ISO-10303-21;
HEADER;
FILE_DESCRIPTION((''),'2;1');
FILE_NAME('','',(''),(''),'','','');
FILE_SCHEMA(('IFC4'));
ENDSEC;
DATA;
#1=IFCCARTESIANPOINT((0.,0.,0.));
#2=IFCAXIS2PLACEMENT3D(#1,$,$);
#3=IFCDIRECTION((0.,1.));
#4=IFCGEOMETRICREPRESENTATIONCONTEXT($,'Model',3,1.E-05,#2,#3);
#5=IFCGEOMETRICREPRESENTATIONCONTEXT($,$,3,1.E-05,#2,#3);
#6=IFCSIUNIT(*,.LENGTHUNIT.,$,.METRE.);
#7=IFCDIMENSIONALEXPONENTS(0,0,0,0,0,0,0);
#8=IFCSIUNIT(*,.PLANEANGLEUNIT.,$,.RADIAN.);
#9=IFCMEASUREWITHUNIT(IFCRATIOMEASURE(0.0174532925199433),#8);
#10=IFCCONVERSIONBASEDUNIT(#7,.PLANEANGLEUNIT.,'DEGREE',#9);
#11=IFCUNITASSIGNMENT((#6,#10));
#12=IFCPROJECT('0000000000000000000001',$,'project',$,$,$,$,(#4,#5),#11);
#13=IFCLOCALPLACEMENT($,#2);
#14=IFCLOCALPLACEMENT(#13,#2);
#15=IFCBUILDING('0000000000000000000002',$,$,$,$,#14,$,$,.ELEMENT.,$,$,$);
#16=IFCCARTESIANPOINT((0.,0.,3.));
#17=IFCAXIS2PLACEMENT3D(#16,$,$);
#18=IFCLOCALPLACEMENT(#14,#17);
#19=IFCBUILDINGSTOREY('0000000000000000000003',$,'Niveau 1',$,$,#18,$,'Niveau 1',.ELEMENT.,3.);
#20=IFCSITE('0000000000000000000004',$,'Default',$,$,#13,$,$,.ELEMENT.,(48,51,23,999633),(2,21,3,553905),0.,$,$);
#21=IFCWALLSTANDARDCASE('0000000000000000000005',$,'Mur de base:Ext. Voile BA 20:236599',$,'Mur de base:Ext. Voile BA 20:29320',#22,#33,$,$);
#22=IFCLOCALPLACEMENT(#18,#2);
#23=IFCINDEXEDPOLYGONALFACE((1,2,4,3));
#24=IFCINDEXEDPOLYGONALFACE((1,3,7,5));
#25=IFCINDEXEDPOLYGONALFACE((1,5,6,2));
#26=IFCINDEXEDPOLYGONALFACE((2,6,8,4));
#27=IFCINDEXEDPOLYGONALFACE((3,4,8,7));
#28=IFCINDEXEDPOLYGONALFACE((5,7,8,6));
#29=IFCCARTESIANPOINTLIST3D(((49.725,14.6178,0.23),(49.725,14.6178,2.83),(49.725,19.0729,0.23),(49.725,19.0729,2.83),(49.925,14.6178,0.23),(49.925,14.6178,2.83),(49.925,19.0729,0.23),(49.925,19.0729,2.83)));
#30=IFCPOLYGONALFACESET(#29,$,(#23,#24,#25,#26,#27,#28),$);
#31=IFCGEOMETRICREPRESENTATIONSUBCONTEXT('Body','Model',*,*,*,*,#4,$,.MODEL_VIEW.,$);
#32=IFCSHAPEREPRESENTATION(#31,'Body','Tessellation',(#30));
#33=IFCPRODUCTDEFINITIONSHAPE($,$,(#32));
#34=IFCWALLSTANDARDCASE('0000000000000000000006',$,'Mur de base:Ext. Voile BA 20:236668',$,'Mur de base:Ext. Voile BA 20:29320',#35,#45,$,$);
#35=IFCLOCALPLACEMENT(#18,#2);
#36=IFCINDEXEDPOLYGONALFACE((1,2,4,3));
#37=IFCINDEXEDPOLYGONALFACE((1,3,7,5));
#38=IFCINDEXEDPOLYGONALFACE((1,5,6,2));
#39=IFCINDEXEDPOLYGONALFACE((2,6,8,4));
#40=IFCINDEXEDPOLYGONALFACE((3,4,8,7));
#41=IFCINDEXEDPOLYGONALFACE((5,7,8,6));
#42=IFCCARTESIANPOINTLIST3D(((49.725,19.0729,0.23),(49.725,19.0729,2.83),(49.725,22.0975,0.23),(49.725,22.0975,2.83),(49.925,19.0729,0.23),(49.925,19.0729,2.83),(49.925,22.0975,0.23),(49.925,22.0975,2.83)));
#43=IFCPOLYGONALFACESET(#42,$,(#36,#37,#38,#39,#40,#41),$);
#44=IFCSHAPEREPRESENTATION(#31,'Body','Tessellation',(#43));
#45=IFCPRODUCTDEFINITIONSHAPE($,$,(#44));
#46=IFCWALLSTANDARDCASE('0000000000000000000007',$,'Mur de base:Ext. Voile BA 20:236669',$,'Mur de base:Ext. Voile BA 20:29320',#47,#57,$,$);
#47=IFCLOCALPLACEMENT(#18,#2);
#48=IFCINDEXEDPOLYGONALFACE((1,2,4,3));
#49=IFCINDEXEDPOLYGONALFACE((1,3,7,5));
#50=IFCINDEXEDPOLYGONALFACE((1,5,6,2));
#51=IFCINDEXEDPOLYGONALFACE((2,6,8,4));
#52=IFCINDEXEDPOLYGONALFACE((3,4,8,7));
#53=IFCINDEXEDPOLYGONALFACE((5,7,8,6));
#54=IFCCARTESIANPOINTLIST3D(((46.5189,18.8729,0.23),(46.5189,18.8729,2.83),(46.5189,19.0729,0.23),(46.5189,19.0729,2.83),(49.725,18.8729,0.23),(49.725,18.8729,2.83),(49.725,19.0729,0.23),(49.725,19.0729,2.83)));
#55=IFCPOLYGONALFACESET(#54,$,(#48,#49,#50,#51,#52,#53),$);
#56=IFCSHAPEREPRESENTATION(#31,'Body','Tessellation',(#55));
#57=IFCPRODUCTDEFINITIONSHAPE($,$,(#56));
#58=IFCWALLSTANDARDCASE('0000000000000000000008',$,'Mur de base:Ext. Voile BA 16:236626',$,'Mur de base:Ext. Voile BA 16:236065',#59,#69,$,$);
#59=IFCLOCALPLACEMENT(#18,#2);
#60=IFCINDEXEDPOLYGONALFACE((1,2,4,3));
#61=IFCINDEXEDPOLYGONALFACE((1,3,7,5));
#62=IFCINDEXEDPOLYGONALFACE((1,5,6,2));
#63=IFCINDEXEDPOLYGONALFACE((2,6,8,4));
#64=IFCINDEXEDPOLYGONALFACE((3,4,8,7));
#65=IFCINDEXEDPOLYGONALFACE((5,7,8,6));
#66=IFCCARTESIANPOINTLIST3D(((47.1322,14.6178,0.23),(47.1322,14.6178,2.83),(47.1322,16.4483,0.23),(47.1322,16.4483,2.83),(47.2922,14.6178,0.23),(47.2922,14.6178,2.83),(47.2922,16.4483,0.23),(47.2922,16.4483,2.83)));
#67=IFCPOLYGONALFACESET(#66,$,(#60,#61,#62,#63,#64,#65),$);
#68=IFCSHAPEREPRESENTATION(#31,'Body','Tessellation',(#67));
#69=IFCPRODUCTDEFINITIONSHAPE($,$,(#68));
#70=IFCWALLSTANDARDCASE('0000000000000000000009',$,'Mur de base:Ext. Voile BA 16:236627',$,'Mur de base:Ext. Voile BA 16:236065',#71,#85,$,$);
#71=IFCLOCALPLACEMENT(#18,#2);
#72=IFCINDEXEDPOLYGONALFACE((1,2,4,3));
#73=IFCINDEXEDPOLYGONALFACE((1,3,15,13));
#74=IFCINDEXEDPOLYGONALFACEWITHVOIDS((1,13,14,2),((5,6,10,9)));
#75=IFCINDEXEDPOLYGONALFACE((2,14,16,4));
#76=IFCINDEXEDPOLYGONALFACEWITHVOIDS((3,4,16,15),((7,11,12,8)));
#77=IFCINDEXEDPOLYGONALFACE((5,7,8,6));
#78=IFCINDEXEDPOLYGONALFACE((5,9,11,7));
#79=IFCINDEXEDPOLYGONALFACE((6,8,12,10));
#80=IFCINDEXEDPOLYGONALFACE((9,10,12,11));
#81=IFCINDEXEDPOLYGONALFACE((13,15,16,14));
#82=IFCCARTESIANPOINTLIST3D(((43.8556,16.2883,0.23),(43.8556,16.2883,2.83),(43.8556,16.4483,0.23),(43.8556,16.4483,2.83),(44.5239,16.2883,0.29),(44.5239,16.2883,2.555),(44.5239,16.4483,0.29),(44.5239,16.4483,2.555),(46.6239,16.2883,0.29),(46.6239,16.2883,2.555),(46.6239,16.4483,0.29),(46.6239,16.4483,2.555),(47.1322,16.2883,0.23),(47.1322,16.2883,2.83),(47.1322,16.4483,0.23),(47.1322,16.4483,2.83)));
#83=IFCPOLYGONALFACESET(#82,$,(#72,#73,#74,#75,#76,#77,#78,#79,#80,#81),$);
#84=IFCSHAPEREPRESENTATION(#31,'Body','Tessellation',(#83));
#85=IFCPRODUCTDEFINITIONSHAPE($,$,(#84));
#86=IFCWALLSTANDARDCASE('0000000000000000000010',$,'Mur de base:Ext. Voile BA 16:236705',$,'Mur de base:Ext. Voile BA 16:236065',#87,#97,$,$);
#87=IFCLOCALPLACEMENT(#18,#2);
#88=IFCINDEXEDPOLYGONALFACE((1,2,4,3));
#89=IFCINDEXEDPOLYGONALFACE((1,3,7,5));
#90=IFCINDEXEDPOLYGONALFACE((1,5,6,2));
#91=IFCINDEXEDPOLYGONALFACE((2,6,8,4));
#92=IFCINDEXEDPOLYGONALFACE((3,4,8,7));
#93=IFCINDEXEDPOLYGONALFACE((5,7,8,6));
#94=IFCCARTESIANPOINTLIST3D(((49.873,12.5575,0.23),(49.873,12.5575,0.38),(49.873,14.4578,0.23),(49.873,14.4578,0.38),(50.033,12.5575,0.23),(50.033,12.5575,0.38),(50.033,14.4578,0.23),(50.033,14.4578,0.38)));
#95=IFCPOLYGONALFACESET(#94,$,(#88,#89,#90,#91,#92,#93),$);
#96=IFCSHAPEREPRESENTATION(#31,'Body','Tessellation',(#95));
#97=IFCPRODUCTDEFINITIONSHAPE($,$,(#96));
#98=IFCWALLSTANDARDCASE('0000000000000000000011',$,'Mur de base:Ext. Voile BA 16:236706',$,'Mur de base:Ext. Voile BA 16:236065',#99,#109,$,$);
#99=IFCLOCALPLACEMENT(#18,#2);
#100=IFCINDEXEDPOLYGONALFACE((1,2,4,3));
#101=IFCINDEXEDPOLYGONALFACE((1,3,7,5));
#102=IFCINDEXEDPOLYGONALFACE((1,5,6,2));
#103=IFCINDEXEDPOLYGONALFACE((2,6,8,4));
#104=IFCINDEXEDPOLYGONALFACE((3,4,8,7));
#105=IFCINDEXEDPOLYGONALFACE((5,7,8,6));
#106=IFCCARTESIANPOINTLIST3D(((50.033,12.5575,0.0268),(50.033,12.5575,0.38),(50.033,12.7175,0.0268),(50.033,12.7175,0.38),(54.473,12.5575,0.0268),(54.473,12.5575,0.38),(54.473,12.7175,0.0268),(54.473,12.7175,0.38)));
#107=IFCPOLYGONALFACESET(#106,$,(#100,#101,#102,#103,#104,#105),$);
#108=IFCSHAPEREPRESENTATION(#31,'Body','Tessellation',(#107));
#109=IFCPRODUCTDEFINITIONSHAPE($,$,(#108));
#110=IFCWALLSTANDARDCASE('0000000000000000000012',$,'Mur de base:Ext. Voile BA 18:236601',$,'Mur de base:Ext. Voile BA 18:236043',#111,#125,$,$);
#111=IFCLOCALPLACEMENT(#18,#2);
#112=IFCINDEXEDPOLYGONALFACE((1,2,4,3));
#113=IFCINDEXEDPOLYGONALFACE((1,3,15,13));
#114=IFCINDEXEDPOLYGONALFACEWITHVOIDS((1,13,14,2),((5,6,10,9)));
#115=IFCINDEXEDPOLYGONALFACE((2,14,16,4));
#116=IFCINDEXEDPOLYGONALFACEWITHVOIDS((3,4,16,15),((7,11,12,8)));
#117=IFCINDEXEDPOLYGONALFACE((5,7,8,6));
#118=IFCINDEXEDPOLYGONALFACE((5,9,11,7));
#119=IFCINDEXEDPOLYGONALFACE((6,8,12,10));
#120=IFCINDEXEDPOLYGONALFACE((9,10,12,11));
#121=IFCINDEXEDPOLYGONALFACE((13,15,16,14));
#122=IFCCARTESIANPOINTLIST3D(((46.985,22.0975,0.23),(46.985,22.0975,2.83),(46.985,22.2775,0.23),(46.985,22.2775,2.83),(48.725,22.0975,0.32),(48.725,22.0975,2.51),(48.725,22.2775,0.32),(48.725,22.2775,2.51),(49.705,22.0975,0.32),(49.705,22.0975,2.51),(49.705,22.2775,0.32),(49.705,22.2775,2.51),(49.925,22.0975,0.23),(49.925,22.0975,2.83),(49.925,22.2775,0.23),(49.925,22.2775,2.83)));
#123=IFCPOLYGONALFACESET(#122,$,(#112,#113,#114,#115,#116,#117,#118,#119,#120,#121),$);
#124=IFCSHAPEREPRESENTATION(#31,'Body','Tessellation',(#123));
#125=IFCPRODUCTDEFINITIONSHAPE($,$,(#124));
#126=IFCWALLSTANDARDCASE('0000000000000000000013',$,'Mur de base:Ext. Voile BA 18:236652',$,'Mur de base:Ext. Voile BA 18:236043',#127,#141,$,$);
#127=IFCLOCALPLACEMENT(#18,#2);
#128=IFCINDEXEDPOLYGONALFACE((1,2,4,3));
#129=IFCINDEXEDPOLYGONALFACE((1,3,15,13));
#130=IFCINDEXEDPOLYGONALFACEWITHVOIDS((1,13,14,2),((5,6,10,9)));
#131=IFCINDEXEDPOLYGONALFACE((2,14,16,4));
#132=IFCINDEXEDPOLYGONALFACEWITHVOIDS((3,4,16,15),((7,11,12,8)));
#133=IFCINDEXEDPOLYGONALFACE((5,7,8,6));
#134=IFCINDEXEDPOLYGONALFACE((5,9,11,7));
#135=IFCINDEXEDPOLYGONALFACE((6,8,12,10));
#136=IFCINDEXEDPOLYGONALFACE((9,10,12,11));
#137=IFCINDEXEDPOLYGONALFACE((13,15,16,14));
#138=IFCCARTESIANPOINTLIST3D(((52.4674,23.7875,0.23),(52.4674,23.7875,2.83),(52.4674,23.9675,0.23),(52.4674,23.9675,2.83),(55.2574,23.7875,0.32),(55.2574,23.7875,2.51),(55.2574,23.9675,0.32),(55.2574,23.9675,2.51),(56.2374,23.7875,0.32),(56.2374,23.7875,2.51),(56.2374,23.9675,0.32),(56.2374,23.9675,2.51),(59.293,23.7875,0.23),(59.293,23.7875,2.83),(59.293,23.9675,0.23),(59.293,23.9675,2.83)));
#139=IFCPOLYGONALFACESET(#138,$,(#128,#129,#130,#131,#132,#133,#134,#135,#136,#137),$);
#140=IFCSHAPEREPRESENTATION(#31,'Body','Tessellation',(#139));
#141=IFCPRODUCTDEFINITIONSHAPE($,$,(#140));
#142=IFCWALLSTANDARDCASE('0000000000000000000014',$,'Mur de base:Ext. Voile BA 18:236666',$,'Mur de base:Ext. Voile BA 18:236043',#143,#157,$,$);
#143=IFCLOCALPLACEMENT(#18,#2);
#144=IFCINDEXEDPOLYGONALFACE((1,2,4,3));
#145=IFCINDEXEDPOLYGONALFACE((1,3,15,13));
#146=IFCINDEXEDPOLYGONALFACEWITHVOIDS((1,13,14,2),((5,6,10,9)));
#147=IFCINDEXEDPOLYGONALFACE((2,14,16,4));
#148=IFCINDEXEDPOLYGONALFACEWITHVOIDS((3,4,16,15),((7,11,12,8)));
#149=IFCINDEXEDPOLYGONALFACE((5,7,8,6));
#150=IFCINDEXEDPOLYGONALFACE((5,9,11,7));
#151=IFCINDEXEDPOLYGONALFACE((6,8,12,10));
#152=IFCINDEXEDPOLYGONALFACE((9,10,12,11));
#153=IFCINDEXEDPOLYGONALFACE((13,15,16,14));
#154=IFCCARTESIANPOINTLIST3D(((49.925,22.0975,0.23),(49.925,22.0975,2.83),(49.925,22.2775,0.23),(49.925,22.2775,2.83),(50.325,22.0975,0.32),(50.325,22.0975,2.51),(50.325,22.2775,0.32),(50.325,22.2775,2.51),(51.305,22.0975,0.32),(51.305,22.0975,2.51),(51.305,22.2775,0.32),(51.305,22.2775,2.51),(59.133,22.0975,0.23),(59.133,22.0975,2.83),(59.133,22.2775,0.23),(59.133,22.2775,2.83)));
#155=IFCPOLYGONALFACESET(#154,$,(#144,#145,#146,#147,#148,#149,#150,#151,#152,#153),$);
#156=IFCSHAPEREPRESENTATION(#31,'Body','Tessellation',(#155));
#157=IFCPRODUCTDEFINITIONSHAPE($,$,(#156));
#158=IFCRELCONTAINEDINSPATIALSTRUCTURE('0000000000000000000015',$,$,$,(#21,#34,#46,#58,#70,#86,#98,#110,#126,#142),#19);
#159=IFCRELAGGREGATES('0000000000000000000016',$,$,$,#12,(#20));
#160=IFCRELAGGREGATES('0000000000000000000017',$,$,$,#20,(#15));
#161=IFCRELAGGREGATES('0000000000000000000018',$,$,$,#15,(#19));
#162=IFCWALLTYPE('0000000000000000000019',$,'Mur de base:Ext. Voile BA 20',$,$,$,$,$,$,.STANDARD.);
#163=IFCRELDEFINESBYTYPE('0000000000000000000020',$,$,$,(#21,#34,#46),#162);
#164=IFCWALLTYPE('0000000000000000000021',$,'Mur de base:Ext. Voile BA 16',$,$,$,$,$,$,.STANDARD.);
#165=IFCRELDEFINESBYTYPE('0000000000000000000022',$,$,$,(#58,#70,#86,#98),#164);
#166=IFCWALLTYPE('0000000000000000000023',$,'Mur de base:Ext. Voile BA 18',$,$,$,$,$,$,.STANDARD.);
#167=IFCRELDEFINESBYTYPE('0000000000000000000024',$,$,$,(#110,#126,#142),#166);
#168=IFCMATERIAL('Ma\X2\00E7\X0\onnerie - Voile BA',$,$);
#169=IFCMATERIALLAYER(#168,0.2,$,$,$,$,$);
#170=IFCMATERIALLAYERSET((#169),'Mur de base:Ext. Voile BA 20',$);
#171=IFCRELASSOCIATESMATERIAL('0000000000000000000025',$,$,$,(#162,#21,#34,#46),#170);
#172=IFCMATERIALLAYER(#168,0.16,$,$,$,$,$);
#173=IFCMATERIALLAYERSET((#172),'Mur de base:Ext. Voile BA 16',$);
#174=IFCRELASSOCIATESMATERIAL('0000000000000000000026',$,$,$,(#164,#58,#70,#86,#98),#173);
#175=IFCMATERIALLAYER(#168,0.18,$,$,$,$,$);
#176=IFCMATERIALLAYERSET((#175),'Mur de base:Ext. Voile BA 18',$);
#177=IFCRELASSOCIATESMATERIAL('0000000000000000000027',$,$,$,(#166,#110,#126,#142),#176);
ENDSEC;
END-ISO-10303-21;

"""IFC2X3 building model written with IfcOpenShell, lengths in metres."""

from ifc_helpers import new_model, entity, si_unit, converted_unit, direction, frame, frame_2d, origin, place, context, subcontext, project, spatial, rectangle, extrude, material, layer, layer_set, layer_usage, type_object, element, save


model = new_model("IFC2X3")

# Units and contexts
model_context = context("Model", 3, precision=1e-05, world=origin(), true_north=direction((0.0, 1.0)))
context_of_model = context(None, 3, precision=1e-05, world=origin(), true_north=direction((0.0, 1.0)))
body_context = subcontext(model_context, "Body", "Model", "MODEL_VIEW")
ifc_project = project(units=[si_unit("LENGTHUNIT", "METRE"), converted_unit("PLANEANGLEUNIT", "DEGREE", entity("IfcRatioMeasure", 0.0174532925199433), si_unit("PLANEANGLEUNIT", "RADIAN"), dimensions=[0, 0, 0, 0, 0, 0, 0])], contexts=[model_context, context_of_model])

# Site, building, storey
site_placement = place(None, origin())
site = spatial("IfcSite", under=ifc_project, at=site_placement, Name="Default", CompositionType="ELEMENT", RefLatitude=(48, 51, 23, 999633), RefLongitude=(2, 21, 3, 553905), RefElevation=0.0)
building_placement = place(site_placement, origin())
building = spatial("IfcBuilding", under=site, at=building_placement, CompositionType="ELEMENT")
storey_placement = place(building_placement, frame((0.0, 0.0, 3.0)))
storey = spatial("IfcBuildingStorey", under=building, at=storey_placement, Name="Niveau 1", LongName="Niveau 1", CompositionType="ELEMENT", Elevation=3.0)

# Walls
ifc_material = material(Name="Maçonnerie - Voile BA")
ifc_layer_1 = layer(ifc_material, 0.2)
ifc_layer_set_1 = layer_set([ifc_layer_1], Name="Mur de base:Ext. Voile BA 20")
ifc_layer_usage_1 = layer_usage(ifc_layer_set_1, "AXIS2", "NEGATIVE", 0.1)
wall_type_1 = type_object("IfcWallType", Name="Mur de base:Ext. Voile BA 20", PredefinedType="STANDARD", material=ifc_layer_set_1)
wall_1_placement = place(storey_placement, frame((49.825, 19.0729, 0.23), z_axis=(0.0, 0.0, 1.0), x_axis=(0.0, -1.0, 0.0)))
element("IfcWallStandardCase", 1, at=wall_1_placement, inside=storey, type_object=wall_type_1, material=ifc_layer_usage_1, Name="Mur de base:Ext. Voile BA 20:236599", ObjectType="Mur de base:Ext. Voile BA 20:29320", context=body_context, shape_type="SweptSolid", body=[
    extrude(rectangle(XDim=4.4551, YDim=0.2, at=frame_2d((2.2275, 0.0), x_axis=(-1.0, 0.0))), origin(), (0.0, 0.0, 1.0), 2.6),
])
ifc_layer_usage_2 = layer_usage(ifc_layer_set_1, "AXIS2", "NEGATIVE", 0.1)
wall_2_placement = place(storey_placement, frame((49.825, 19.0729, 0.23), z_axis=(0.0, 0.0, 1.0), x_axis=(0.0, 1.0, 0.0)))
element("IfcWallStandardCase", 2, at=wall_2_placement, inside=storey, type_object=wall_type_1, material=ifc_layer_usage_2, Name="Mur de base:Ext. Voile BA 20:236668", ObjectType="Mur de base:Ext. Voile BA 20:29320", context=body_context, shape_type="SweptSolid", body=[
    extrude(rectangle(XDim=3.0246, YDim=0.2, at=frame_2d((1.5123, 0.0), x_axis=(-1.0, 0.0))), origin(), (0.0, 0.0, 1.0), 2.6),
])
ifc_layer_usage_3 = layer_usage(ifc_layer_set_1, "AXIS2", "POSITIVE", -0.1)
wall_3_placement = place(storey_placement, frame((49.725, 18.9729, 0.23), z_axis=(0.0, 0.0, 1.0), x_axis=(-1.0, 0.0, 0.0)))
element("IfcWallStandardCase", 3, at=wall_3_placement, inside=storey, type_object=wall_type_1, material=ifc_layer_usage_3, Name="Mur de base:Ext. Voile BA 20:236669", ObjectType="Mur de base:Ext. Voile BA 20:29320", context=body_context, shape_type="SweptSolid", body=[
    extrude(rectangle(XDim=3.2061, YDim=0.2, at=frame_2d((1.6031, 0.0), x_axis=(-1.0, 0.0))), origin(), (0.0, 0.0, 1.0), 2.6),
])
ifc_layer_2 = layer(ifc_material, 0.16)
ifc_layer_set_2 = layer_set([ifc_layer_2], Name="Mur de base:Ext. Voile BA 16")
ifc_layer_usage_4 = layer_usage(ifc_layer_set_2, "AXIS2", "NEGATIVE", 0.08)
wall_type_2 = type_object("IfcWallType", Name="Mur de base:Ext. Voile BA 16", PredefinedType="STANDARD", material=ifc_layer_set_2)
wall_4_placement = place(storey_placement, frame((47.2122, 14.6178, 0.23), z_axis=(0.0, 0.0, 1.0), x_axis=(0.0, 1.0, 0.0)))
element("IfcWallStandardCase", 4, at=wall_4_placement, inside=storey, type_object=wall_type_2, material=ifc_layer_usage_4, Name="Mur de base:Ext. Voile BA 16:236626", ObjectType="Mur de base:Ext. Voile BA 16:236065", context=body_context, shape_type="SweptSolid", body=[
    extrude(rectangle(XDim=1.8304, YDim=0.16, at=frame_2d((0.9152, 0.0), x_axis=(-1.0, 0.0))), origin(), (0.0, 0.0, 1.0), 2.6),
])

# Wall, opening
ifc_layer_usage_5 = layer_usage(ifc_layer_set_2, "AXIS2", "NEGATIVE", 0.08)
wall_5_placement = place(storey_placement, frame((47.1322, 16.3683, 0.23), z_axis=(0.0, 0.0, 1.0), x_axis=(-1.0, 0.0, 0.0)))
wall_5 = element("IfcWallStandardCase", 5, at=wall_5_placement, inside=storey, type_object=wall_type_2, material=ifc_layer_usage_5, Name="Mur de base:Ext. Voile BA 16:236627", ObjectType="Mur de base:Ext. Voile BA 16:236065", context=body_context, shape_type="SweptSolid", body=[
    extrude(rectangle(XDim=3.2767, YDim=0.16, at=frame_2d((1.6383, 0.0), x_axis=(-1.0, 0.0))), origin(), (0.0, 0.0, 1.0), 2.6),
])
opening_1_placement = place(wall_5_placement, origin())
element("IfcOpeningElement", 6, at=opening_1_placement, cuts=wall_5, ObjectType="Opening", context=body_context, shape_type="SweptSolid", body=[
    extrude(rectangle(XDim=2.265, YDim=2.1, at=frame_2d((0.0, 0.0), x_axis=(1.0, 0.0))), frame((1.5583, -0.08, 1.1925), z_axis=(0.0, 1.0, 0.0), x_axis=(0.0, 0.0, -1.0)), (0.0, 0.0, 1.0), 0.16),
])

# Walls
ifc_layer_usage_6 = layer_usage(ifc_layer_set_2, "AXIS2", "POSITIVE", -0.08)
wall_6_placement = place(storey_placement, frame((49.953, 14.4578, 0.23), z_axis=(0.0, 0.0, 1.0), x_axis=(0.0, -1.0, 0.0)))
element("IfcWallStandardCase", 7, at=wall_6_placement, inside=storey, type_object=wall_type_2, material=ifc_layer_usage_6, Name="Mur de base:Ext. Voile BA 16:236705", ObjectType="Mur de base:Ext. Voile BA 16:236065", context=body_context, shape_type="SweptSolid", body=[
    extrude(rectangle(XDim=1.9003, YDim=0.16, at=frame_2d((0.9502, 0.0), x_axis=(-1.0, 0.0))), origin(), (0.0, 0.0, 1.0), 0.15),
])
ifc_layer_usage_7 = layer_usage(ifc_layer_set_2, "AXIS2", "POSITIVE", -0.08)
wall_7_placement = place(storey_placement, frame((50.033, 12.6375, 0.0268)))
element("IfcWallStandardCase", 8, at=wall_7_placement, inside=storey, type_object=wall_type_2, material=ifc_layer_usage_7, Name="Mur de base:Ext. Voile BA 16:236706", ObjectType="Mur de base:Ext. Voile BA 16:236065", context=body_context, shape_type="SweptSolid", body=[
    extrude(rectangle(XDim=4.44, YDim=0.16, at=frame_2d((2.22, 0.0), x_axis=(-1.0, 0.0))), origin(), (0.0, 0.0, 1.0), 0.3532),
])

# Walls, openings
ifc_layer_3 = layer(ifc_material, 0.18)
ifc_layer_set_3 = layer_set([ifc_layer_3], Name="Mur de base:Ext. Voile BA 18")
ifc_layer_usage_8 = layer_usage(ifc_layer_set_3, "AXIS2", "NEGATIVE", 0.09)
wall_type_3 = type_object("IfcWallType", Name="Mur de base:Ext. Voile BA 18", PredefinedType="STANDARD", material=ifc_layer_set_3)
wall_8_placement = place(storey_placement, frame((46.985, 22.1875, 0.23)))
wall_8 = element("IfcWallStandardCase", 9, at=wall_8_placement, inside=storey, type_object=wall_type_3, material=ifc_layer_usage_8, Name="Mur de base:Ext. Voile BA 18:236601", ObjectType="Mur de base:Ext. Voile BA 18:236043", context=body_context, shape_type="SweptSolid", body=[
    extrude(rectangle(XDim=2.94, YDim=0.18, at=frame_2d((1.47, 0.0), x_axis=(-1.0, 0.0))), origin(), (0.0, 0.0, 1.0), 2.6),
])
opening_2_placement = place(wall_8_placement, origin())
element("IfcOpeningElement", 10, at=opening_2_placement, cuts=wall_8, ObjectType="Opening", context=body_context, shape_type="SweptSolid", body=[
    extrude(rectangle(XDim=2.19, YDim=0.98, at=frame_2d((0.0, 0.0), x_axis=(1.0, 0.0))), frame((2.23, -0.09, 1.185), z_axis=(0.0, 1.0, 0.0), x_axis=(0.0, 0.0, -1.0)), (0.0, 0.0, 1.0), 0.18),
])
ifc_layer_usage_9 = layer_usage(ifc_layer_set_3, "AXIS2", "POSITIVE", -0.09)
wall_9_placement = place(storey_placement, frame((52.4674, 23.8775, 0.23)))
wall_9 = element("IfcWallStandardCase", 11, at=wall_9_placement, inside=storey, type_object=wall_type_3, material=ifc_layer_usage_9, Name="Mur de base:Ext. Voile BA 18:236652", ObjectType="Mur de base:Ext. Voile BA 18:236043", context=body_context, shape_type="SweptSolid", body=[
    extrude(rectangle(XDim=6.8256, YDim=0.18, at=frame_2d((3.4128, 0.0), x_axis=(-1.0, 0.0))), origin(), (0.0, 0.0, 1.0), 2.6),
])
opening_3_placement = place(wall_9_placement, origin())
element("IfcOpeningElement", 12, at=opening_3_placement, cuts=wall_9, ObjectType="Opening", context=body_context, shape_type="SweptSolid", body=[
    extrude(rectangle(XDim=2.19, YDim=0.98, at=frame_2d((0.0, 0.0), x_axis=(1.0, 0.0))), frame((3.28, -0.09, 1.185), z_axis=(0.0, 1.0, 0.0), x_axis=(0.0, 0.0, -1.0)), (0.0, 0.0, 1.0), 0.18),
])
ifc_layer_usage_10 = layer_usage(ifc_layer_set_3, "AXIS2", "NEGATIVE", 0.09)
wall_10_placement = place(storey_placement, frame((49.925, 22.1875, 0.23)))
wall_10 = element("IfcWallStandardCase", 13, at=wall_10_placement, inside=storey, type_object=wall_type_3, material=ifc_layer_usage_10, Name="Mur de base:Ext. Voile BA 18:236666", ObjectType="Mur de base:Ext. Voile BA 18:236043", context=body_context, shape_type="SweptSolid", body=[
    extrude(rectangle(XDim=9.208, YDim=0.18, at=frame_2d((4.604, 0.0), x_axis=(-1.0, 0.0))), origin(), (0.0, 0.0, 1.0), 2.6),
])
opening_4_placement = place(wall_10_placement, origin())
element("IfcOpeningElement", 14, at=opening_4_placement, cuts=wall_10, ObjectType="Opening", context=body_context, shape_type="SweptSolid", body=[
    extrude(rectangle(XDim=2.19, YDim=0.98, at=frame_2d((0.0, 0.0), x_axis=(1.0, 0.0))), frame((0.89, -0.09, 1.185), z_axis=(0.0, 1.0, 0.0), x_axis=(0.0, 0.0, -1.0)), (0.0, 0.0, 1.0), 0.18),
])

save(model, "model.ifc")
